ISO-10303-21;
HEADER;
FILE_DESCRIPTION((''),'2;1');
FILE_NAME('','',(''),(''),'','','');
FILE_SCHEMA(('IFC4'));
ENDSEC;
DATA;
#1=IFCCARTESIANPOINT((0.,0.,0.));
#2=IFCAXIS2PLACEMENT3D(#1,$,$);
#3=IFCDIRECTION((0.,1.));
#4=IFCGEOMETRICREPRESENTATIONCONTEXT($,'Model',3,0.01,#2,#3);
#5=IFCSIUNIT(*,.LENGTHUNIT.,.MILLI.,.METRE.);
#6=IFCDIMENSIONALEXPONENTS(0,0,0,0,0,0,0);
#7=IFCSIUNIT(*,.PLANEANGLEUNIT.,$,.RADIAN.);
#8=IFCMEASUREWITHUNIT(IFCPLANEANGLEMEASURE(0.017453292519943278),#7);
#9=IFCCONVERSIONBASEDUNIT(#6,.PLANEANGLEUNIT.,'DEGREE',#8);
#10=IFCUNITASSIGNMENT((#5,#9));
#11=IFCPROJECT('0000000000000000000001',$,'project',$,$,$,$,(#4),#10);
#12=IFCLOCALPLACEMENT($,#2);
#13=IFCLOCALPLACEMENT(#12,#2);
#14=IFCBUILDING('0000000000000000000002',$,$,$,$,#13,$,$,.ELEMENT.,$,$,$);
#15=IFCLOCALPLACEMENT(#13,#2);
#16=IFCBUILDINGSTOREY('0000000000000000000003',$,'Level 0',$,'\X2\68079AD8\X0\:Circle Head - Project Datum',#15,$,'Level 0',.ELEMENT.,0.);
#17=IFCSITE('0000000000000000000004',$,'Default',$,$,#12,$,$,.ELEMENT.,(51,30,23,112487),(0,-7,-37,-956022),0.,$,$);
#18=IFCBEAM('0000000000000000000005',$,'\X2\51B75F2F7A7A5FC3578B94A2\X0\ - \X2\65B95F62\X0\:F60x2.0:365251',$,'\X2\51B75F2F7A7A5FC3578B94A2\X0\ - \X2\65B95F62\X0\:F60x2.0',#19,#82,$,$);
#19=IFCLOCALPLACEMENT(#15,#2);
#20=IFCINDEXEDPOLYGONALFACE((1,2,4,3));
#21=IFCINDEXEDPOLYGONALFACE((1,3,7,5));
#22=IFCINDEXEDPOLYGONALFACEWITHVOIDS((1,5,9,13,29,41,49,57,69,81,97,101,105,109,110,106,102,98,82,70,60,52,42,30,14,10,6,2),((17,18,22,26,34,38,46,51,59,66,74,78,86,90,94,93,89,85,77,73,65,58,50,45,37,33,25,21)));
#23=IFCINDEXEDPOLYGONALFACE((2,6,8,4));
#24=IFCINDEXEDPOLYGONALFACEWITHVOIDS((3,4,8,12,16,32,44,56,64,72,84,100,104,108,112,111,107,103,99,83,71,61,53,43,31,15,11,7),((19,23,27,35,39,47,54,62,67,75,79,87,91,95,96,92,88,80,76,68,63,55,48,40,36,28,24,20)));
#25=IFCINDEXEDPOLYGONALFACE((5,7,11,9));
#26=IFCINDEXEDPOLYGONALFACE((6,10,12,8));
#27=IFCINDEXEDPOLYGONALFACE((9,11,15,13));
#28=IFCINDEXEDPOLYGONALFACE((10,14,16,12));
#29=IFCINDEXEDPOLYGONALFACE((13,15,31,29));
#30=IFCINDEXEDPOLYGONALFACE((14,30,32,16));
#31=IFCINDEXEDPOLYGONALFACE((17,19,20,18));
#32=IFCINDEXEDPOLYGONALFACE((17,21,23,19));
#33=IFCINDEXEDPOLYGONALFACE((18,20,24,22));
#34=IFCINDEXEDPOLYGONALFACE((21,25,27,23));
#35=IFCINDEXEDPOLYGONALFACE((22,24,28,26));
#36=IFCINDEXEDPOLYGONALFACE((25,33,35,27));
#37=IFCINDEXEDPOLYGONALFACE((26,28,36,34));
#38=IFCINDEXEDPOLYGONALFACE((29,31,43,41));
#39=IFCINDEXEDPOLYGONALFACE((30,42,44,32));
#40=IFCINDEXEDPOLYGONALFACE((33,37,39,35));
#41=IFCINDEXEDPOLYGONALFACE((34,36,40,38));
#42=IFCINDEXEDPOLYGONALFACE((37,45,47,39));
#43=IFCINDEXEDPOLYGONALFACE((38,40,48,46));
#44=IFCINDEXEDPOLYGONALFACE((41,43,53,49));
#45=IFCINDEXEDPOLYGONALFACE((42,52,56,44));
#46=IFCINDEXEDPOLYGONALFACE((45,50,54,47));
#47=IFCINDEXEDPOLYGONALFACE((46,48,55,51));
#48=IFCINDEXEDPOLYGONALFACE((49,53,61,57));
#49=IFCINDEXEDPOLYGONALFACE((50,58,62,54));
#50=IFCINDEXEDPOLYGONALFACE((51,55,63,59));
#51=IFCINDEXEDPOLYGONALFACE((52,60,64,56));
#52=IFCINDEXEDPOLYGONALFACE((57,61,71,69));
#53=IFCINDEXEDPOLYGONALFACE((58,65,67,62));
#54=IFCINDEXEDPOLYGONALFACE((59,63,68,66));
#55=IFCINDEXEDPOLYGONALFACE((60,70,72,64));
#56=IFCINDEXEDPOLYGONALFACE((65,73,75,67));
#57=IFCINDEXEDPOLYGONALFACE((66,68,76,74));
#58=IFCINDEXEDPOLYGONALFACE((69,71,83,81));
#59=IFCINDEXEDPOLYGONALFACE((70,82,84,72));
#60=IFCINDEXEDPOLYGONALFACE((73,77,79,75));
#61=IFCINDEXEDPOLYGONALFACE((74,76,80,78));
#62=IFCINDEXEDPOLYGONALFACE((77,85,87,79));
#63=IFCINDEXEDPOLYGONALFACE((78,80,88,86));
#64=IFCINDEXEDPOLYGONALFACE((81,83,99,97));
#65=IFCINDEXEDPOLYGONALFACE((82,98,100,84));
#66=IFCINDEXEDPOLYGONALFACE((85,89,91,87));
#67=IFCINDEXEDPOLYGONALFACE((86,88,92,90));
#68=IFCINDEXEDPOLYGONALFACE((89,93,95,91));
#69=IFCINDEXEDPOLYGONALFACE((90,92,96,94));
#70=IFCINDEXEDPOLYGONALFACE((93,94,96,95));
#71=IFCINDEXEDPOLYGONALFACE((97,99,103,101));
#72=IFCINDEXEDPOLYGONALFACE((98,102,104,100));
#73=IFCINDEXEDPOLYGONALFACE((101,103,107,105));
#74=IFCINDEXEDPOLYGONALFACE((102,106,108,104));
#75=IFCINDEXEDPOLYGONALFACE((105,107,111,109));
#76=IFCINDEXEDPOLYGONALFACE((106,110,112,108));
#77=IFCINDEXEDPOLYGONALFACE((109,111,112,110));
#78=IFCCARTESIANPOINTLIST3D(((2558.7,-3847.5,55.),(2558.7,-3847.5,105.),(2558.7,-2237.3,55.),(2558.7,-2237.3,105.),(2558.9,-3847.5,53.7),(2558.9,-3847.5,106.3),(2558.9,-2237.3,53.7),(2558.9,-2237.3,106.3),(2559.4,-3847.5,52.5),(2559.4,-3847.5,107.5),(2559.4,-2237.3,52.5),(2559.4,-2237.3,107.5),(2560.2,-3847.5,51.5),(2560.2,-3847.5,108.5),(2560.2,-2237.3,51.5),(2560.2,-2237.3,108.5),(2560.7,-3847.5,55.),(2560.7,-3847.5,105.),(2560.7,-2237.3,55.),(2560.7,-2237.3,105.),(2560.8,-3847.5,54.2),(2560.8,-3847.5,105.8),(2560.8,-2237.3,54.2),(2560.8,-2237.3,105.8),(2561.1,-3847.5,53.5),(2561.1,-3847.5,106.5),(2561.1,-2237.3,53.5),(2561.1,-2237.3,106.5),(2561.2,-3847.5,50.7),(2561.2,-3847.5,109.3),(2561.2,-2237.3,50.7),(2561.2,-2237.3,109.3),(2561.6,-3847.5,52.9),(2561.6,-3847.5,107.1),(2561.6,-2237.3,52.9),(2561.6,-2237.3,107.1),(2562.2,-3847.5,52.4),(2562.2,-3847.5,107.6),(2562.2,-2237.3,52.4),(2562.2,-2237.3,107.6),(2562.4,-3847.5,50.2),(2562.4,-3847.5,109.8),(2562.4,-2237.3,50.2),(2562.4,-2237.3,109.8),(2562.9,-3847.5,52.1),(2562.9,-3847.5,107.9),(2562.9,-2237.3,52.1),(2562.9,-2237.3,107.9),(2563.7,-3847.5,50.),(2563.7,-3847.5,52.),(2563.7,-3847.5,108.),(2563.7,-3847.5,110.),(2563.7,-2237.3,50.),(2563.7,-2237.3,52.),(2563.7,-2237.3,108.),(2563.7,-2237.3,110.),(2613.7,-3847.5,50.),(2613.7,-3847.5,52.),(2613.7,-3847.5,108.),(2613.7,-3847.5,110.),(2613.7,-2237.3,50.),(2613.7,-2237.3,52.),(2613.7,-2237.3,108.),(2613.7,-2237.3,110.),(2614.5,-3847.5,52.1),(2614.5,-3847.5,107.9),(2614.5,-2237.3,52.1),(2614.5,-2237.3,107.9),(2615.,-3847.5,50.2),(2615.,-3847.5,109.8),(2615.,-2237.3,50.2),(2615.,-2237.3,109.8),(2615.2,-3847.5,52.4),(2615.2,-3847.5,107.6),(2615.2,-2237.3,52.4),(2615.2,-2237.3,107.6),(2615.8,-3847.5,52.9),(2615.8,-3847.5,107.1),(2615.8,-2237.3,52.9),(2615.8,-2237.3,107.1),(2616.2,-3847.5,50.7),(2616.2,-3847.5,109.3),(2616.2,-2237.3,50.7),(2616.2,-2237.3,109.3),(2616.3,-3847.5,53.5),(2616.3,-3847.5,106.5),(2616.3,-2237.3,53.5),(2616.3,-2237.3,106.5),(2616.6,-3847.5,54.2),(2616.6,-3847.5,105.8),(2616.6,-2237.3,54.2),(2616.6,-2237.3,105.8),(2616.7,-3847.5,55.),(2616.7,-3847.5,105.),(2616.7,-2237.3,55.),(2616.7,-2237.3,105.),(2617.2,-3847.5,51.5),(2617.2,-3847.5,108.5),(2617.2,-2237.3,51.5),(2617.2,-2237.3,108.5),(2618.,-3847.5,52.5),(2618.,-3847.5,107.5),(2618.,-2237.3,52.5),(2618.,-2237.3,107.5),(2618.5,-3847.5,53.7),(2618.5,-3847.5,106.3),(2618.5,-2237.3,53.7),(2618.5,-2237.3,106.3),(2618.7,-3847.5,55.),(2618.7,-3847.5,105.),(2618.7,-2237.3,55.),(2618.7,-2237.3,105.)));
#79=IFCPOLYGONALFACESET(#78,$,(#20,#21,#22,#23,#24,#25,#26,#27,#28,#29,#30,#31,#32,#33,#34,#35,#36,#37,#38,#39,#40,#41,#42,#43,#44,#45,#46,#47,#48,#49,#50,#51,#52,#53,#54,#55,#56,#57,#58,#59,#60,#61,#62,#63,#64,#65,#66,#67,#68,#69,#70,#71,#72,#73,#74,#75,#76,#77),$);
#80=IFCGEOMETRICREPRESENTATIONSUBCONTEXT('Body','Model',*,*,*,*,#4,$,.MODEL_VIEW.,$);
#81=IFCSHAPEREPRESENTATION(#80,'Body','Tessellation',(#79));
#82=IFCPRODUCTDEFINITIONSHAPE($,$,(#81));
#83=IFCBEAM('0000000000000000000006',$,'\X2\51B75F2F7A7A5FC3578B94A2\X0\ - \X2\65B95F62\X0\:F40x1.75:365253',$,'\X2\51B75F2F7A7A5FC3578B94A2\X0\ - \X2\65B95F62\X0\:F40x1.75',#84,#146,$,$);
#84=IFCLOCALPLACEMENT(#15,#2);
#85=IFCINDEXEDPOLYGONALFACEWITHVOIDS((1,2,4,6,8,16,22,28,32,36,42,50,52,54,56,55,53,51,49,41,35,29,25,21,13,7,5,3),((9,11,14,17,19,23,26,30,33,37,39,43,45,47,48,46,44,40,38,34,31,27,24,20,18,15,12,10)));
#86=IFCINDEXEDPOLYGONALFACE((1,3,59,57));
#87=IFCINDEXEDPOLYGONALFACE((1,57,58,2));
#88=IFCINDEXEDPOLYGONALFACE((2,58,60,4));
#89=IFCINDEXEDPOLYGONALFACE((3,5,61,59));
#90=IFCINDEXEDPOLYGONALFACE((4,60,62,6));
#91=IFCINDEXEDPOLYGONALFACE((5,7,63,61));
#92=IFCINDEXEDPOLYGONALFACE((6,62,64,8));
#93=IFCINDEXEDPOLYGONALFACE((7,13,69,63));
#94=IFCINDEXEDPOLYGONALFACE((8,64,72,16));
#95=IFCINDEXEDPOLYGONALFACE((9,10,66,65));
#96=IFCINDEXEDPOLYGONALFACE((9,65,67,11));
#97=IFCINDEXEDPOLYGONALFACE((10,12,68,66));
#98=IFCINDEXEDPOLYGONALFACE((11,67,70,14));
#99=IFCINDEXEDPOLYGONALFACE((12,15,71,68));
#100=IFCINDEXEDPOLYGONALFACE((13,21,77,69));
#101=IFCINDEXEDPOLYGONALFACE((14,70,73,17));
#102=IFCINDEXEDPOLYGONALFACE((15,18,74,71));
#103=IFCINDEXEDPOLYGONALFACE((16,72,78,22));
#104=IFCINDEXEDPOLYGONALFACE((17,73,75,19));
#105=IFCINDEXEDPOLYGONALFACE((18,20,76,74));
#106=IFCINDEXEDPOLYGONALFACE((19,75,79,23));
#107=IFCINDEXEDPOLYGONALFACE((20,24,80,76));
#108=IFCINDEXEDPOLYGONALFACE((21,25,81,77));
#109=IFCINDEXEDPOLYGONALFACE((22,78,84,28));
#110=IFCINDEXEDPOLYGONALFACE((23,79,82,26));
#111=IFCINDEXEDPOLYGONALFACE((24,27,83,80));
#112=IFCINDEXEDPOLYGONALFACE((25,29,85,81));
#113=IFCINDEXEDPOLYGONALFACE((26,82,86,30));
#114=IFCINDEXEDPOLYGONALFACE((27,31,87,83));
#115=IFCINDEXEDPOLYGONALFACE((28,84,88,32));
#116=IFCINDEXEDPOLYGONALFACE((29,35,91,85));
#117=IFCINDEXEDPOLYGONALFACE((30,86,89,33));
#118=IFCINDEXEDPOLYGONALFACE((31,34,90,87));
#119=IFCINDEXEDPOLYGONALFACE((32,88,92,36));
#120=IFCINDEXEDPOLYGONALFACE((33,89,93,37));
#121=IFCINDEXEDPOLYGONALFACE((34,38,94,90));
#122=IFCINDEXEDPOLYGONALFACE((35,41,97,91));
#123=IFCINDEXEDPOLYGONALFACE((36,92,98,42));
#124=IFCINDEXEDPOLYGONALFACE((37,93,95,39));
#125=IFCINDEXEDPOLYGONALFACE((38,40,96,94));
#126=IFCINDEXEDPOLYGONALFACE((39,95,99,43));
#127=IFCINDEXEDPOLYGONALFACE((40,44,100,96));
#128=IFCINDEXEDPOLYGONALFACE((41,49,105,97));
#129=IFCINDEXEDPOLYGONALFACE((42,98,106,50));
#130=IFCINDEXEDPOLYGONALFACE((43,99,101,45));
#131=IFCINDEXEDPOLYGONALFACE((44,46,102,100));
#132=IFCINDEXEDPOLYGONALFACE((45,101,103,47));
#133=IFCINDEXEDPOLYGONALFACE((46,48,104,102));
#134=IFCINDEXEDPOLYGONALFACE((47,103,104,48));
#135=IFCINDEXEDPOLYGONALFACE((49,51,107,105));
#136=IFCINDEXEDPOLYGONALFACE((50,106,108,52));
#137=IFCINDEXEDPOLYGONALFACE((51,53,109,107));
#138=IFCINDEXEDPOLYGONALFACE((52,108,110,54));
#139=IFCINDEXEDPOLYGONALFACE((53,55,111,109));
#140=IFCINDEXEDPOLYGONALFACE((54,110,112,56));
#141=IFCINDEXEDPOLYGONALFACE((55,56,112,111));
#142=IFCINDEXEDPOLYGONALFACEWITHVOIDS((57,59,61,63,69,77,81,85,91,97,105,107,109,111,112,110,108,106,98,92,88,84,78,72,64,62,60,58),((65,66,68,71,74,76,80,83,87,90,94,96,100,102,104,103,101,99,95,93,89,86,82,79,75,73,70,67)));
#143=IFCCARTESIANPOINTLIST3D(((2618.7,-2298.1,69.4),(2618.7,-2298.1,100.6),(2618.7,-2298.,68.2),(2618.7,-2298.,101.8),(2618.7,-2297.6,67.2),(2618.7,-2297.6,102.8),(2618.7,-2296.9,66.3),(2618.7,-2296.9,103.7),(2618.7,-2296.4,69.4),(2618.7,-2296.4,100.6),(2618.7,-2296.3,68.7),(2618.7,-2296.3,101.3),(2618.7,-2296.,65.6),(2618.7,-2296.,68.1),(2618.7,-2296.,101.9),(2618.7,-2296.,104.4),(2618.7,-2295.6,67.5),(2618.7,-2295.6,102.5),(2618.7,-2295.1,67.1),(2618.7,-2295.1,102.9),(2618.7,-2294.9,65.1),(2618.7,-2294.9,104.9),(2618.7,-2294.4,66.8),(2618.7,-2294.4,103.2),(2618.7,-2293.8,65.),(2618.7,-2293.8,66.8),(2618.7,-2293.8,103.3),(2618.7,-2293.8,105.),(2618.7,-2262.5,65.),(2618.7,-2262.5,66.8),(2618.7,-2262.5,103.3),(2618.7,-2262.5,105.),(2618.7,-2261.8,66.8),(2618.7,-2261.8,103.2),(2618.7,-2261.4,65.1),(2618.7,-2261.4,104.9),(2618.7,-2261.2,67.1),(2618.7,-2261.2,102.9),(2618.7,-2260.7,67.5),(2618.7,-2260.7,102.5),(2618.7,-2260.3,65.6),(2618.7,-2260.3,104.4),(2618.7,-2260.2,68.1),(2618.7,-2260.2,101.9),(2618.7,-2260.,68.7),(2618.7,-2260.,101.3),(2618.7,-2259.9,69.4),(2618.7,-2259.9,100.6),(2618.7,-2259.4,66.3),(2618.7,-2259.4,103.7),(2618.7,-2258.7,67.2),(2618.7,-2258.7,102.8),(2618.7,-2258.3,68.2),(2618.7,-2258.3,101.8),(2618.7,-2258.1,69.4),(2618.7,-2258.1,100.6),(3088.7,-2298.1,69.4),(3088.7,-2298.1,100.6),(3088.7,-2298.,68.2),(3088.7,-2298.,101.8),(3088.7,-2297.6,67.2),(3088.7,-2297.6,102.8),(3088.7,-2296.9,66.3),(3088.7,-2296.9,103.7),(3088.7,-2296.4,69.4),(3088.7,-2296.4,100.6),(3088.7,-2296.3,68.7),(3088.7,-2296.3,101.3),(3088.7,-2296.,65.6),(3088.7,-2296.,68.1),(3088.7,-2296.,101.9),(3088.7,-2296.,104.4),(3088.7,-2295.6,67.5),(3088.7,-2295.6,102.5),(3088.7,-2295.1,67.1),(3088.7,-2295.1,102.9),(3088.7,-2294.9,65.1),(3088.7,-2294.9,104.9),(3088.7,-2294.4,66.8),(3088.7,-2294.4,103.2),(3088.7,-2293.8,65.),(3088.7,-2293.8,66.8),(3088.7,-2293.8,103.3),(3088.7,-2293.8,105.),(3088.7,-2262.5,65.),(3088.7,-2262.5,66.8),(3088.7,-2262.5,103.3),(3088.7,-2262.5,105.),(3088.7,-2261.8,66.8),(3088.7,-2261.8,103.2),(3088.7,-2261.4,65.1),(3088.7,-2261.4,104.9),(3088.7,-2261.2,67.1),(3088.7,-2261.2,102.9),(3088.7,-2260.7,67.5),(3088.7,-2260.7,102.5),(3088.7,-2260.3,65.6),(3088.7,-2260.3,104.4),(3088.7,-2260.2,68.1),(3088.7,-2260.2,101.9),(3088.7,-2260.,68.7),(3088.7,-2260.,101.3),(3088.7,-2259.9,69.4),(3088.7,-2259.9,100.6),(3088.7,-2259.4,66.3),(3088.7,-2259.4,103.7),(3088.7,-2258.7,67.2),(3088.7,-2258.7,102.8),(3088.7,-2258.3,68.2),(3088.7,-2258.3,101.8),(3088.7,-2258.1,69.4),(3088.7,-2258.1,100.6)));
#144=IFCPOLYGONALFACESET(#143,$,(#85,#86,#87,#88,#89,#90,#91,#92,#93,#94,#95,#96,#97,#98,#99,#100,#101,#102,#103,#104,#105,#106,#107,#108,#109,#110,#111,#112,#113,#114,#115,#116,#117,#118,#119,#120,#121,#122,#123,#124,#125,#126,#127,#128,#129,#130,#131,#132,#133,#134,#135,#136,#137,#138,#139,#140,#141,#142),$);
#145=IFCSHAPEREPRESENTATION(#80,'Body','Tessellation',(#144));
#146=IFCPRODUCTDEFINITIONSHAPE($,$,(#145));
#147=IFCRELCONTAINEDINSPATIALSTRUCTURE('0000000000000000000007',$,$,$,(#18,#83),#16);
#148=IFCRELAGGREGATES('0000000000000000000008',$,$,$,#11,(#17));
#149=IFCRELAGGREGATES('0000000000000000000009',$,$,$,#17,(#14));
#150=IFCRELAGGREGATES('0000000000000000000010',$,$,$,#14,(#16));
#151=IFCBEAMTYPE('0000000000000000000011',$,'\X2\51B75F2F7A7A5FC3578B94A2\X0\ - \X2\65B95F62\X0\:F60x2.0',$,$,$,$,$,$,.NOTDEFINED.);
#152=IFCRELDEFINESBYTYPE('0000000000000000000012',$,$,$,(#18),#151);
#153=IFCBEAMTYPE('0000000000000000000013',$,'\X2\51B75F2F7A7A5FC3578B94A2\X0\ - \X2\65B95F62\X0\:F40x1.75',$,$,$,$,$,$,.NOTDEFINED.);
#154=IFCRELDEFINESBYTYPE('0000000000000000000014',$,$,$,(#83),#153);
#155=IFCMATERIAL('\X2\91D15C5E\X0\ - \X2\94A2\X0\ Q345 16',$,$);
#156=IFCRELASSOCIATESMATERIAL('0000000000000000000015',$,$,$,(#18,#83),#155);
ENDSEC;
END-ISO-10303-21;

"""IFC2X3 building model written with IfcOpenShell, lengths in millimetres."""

from ifc_helpers import new_model, entity, si_unit, converted_unit, direction, frame, frame_2d, origin, place, context, subcontext, project, spatial, polyline, circle_curve, parameter, trimmed, segment, composite_curve, outline, extrude, material, type_object, element, save


model = new_model("IFC2X3")

# Units and contexts
model_context = context("Model", 3, precision=0.01, world=origin(), true_north=direction((0.0, 1.0)))
body_context = subcontext(model_context, "Body", "Model", "MODEL_VIEW")
ifc_project = project(units=[si_unit("LENGTHUNIT", "METRE", prefix="MILLI"), converted_unit("PLANEANGLEUNIT", "DEGREE", entity("IfcPlaneAngleMeasure", 0.017453292519943278), si_unit("PLANEANGLEUNIT", "RADIAN"), dimensions=[0, 0, 0, 0, 0, 0, 0])], contexts=[model_context])

# Site, building, storey
site_placement = place(None, origin())
site = spatial("IfcSite", under=ifc_project, at=site_placement, Name="Default", CompositionType="ELEMENT", RefLatitude=(51, 30, 23, 112487), RefLongitude=(0, -7, -37, -956022), RefElevation=0.0)
building_placement = place(site_placement, origin())
building = spatial("IfcBuilding", under=site, at=building_placement, CompositionType="ELEMENT")
storey_placement = place(building_placement, origin())
storey = spatial("IfcBuildingStorey", under=building, at=storey_placement, Name="Level 0", ObjectType="标高:Circle Head - Project Datum", LongName="Level 0", CompositionType="ELEMENT", Elevation=0.0)

# Beams
ifc_material_1 = material(Name="金属 - 钢 Q345 16")
beam_type_1 = type_object("IfcBeamType", Name="冷弯空心型钢 - 方形:F60x2.0", PredefinedType="NOTDEFINED")
beam_1_placement = place(storey_placement, frame((2588.7, -3815.6, 110.0), z_axis=(0.0, 0.0, 1.0), x_axis=(0.0, 1.0, 0.0)))
element("IfcBeam", 1, at=beam_1_placement, inside=storey, type_object=beam_type_1, material=ifc_material_1, Name="冷弯空心型钢 - 方形:F60x2.0:365251", ObjectType="冷弯空心型钢 - 方形:F60x2.0", context=body_context, shape_type="SweptSolid", body=[
    extrude(outline(composite_curve([segment(polyline([(-25.0, -30.0), (25.0, -30.0)]), True, "CONTINUOUS"), segment(trimmed(circle_curve(frame_2d((25.0, -25.0), x_axis=(1.0, 0.0)), 5.0), [parameter(270.0)], [parameter(360.0)], True, "PARAMETER"), True, "CONTINUOUS"), segment(polyline([(30.0, -25.0), (30.0, 25.0)]), True, "CONTINUOUS"), segment(trimmed(circle_curve(frame_2d((25.0, 25.0), x_axis=(1.0, 0.0)), 5.0), [parameter(360.0)], [parameter(90.0)], True, "PARAMETER"), True, "CONTINUOUS"), segment(polyline([(25.0, 30.0), (-25.0, 30.0)]), True, "CONTINUOUS"), segment(trimmed(circle_curve(frame_2d((-25.0, 25.0), x_axis=(1.0, 0.0)), 5.0), [parameter(90.0)], [parameter(180.0)], True, "PARAMETER"), True, "CONTINUOUS"), segment(polyline([(-30.0, 25.0), (-30.0, -25.0)]), True, "CONTINUOUS"), segment(trimmed(circle_curve(frame_2d((-25.0, -25.0), x_axis=(1.0, 0.0)), 5.0), [parameter(180.0)], [parameter(270.0)], True, "PARAMETER"), True, "CONTINUOUS")], self_intersect=False), holes=[composite_curve([segment(trimmed(circle_curve(frame_2d((-25.0, -25.0), x_axis=(1.0, 0.0)), 3.0), [parameter(180.0)], [parameter(270.0)], True, "PARAMETER"), False, "CONTINUOUS"), segment(polyline([(-28.0, -25.0), (-28.0, 25.0)]), True, "CONTINUOUS"), segment(trimmed(circle_curve(frame_2d((-25.0, 25.0), x_axis=(1.0, 0.0)), 3.0), [parameter(90.0)], [parameter(180.0)], True, "PARAMETER"), False, "CONTINUOUS"), segment(polyline([(-25.0, 28.0), (25.0, 28.0)]), True, "CONTINUOUS"), segment(trimmed(circle_curve(frame_2d((25.0, 25.0), x_axis=(1.0, 0.0)), 3.0), [parameter(0.0)], [parameter(90.0)], True, "PARAMETER"), False, "CONTINUOUS"), segment(polyline([(28.0, 25.0), (28.0, -25.0)]), True, "CONTINUOUS"), segment(trimmed(circle_curve(frame_2d((25.0, -25.0), x_axis=(1.0, 0.0)), 3.0), [parameter(270.0)], [parameter(360.0)], True, "PARAMETER"), False, "CONTINUOUS"), segment(polyline([(25.0, -28.0), (-25.0, -28.0)]), True, "CONTINUOUS")], self_intersect=False)]), frame((-31.9, 0.0, -30.0), z_axis=(1.0, 0.0, 0.0), x_axis=(0.0, -1.0, 0.0)), (0.0, 0.0, 1.0), 1610.2),
])
beam_type_2 = type_object("IfcBeamType", Name="冷弯空心型钢 - 方形:F40x1.75", PredefinedType="NOTDEFINED")
beam_2_placement = place(storey_placement, frame((3123.7, -2278.1, 105.0), z_axis=(0.0, 0.0, 1.0), x_axis=(-1.0, 0.0, 0.0)))
element("IfcBeam", 2, at=beam_2_placement, inside=storey, type_object=beam_type_2, material=ifc_material_1, Name="冷弯空心型钢 - 方形:F40x1.75:365253", ObjectType="冷弯空心型钢 - 方形:F40x1.75", context=body_context, shape_type="SweptSolid", body=[
    extrude(outline(composite_curve([segment(trimmed(circle_curve(frame_2d((-15.6, 15.6), x_axis=(1.0, 0.0)), 4.4), [parameter(90.0)], [parameter(180.0)], True, "PARAMETER"), True, "CONTINUOUS"), segment(polyline([(-20.0, 15.6), (-20.0, -15.6)]), True, "CONTINUOUS"), segment(trimmed(circle_curve(frame_2d((-15.6, -15.6), x_axis=(1.0, 0.0)), 4.4), [parameter(180.0)], [parameter(270.0)], True, "PARAMETER"), True, "CONTINUOUS"), segment(polyline([(-15.6, -20.0), (15.6, -20.0)]), True, "CONTINUOUS"), segment(trimmed(circle_curve(frame_2d((15.6, -15.6), x_axis=(1.0, 0.0)), 4.4), [parameter(270.0)], [parameter(0.0)], True, "PARAMETER"), True, "CONTINUOUS"), segment(polyline([(20.0, -15.6), (20.0, 15.6)]), True, "CONTINUOUS"), segment(trimmed(circle_curve(frame_2d((15.6, 15.6), x_axis=(1.0, 0.0)), 4.4), [parameter(0.0)], [parameter(90.0)], True, "PARAMETER"), True, "CONTINUOUS"), segment(polyline([(15.6, 20.0), (-15.6, 20.0)]), True, "CONTINUOUS")], self_intersect=False), holes=[composite_curve([segment(polyline([(-15.6, 18.3), (15.6, 18.3)]), True, "CONTINUOUS"), segment(trimmed(circle_curve(frame_2d((15.6, 15.6), x_axis=(1.0, 0.0)), 2.6), [parameter(0.0)], [parameter(90.0)], True, "PARAMETER"), False, "CONTINUOUS"), segment(polyline([(18.2, 15.6), (18.2, -15.6)]), True, "CONTINUOUS"), segment(trimmed(circle_curve(frame_2d((15.6, -15.6), x_axis=(1.0, 0.0)), 2.6), [parameter(270.0)], [parameter(360.0)], True, "PARAMETER"), False, "CONTINUOUS"), segment(polyline([(15.6, -18.2), (-15.6, -18.2)]), True, "CONTINUOUS"), segment(trimmed(circle_curve(frame_2d((-15.6, -15.6), x_axis=(1.0, 0.0)), 2.6), [parameter(180.0)], [parameter(270.0)], True, "PARAMETER"), False, "CONTINUOUS"), segment(polyline([(-18.3, -15.6), (-18.3, 15.6)]), True, "CONTINUOUS"), segment(trimmed(circle_curve(frame_2d((-15.6, 15.6), x_axis=(1.0, 0.0)), 2.6), [parameter(90.0)], [parameter(180.0)], True, "PARAMETER"), False, "CONTINUOUS")], self_intersect=False)]), frame((35.0, 0.0, -20.0), z_axis=(1.0, 0.0, 0.0), x_axis=(0.0, 1.0, 0.0)), (0.0, 0.0, 1.0), 470.0),
])

save(model, "model.ifc")
